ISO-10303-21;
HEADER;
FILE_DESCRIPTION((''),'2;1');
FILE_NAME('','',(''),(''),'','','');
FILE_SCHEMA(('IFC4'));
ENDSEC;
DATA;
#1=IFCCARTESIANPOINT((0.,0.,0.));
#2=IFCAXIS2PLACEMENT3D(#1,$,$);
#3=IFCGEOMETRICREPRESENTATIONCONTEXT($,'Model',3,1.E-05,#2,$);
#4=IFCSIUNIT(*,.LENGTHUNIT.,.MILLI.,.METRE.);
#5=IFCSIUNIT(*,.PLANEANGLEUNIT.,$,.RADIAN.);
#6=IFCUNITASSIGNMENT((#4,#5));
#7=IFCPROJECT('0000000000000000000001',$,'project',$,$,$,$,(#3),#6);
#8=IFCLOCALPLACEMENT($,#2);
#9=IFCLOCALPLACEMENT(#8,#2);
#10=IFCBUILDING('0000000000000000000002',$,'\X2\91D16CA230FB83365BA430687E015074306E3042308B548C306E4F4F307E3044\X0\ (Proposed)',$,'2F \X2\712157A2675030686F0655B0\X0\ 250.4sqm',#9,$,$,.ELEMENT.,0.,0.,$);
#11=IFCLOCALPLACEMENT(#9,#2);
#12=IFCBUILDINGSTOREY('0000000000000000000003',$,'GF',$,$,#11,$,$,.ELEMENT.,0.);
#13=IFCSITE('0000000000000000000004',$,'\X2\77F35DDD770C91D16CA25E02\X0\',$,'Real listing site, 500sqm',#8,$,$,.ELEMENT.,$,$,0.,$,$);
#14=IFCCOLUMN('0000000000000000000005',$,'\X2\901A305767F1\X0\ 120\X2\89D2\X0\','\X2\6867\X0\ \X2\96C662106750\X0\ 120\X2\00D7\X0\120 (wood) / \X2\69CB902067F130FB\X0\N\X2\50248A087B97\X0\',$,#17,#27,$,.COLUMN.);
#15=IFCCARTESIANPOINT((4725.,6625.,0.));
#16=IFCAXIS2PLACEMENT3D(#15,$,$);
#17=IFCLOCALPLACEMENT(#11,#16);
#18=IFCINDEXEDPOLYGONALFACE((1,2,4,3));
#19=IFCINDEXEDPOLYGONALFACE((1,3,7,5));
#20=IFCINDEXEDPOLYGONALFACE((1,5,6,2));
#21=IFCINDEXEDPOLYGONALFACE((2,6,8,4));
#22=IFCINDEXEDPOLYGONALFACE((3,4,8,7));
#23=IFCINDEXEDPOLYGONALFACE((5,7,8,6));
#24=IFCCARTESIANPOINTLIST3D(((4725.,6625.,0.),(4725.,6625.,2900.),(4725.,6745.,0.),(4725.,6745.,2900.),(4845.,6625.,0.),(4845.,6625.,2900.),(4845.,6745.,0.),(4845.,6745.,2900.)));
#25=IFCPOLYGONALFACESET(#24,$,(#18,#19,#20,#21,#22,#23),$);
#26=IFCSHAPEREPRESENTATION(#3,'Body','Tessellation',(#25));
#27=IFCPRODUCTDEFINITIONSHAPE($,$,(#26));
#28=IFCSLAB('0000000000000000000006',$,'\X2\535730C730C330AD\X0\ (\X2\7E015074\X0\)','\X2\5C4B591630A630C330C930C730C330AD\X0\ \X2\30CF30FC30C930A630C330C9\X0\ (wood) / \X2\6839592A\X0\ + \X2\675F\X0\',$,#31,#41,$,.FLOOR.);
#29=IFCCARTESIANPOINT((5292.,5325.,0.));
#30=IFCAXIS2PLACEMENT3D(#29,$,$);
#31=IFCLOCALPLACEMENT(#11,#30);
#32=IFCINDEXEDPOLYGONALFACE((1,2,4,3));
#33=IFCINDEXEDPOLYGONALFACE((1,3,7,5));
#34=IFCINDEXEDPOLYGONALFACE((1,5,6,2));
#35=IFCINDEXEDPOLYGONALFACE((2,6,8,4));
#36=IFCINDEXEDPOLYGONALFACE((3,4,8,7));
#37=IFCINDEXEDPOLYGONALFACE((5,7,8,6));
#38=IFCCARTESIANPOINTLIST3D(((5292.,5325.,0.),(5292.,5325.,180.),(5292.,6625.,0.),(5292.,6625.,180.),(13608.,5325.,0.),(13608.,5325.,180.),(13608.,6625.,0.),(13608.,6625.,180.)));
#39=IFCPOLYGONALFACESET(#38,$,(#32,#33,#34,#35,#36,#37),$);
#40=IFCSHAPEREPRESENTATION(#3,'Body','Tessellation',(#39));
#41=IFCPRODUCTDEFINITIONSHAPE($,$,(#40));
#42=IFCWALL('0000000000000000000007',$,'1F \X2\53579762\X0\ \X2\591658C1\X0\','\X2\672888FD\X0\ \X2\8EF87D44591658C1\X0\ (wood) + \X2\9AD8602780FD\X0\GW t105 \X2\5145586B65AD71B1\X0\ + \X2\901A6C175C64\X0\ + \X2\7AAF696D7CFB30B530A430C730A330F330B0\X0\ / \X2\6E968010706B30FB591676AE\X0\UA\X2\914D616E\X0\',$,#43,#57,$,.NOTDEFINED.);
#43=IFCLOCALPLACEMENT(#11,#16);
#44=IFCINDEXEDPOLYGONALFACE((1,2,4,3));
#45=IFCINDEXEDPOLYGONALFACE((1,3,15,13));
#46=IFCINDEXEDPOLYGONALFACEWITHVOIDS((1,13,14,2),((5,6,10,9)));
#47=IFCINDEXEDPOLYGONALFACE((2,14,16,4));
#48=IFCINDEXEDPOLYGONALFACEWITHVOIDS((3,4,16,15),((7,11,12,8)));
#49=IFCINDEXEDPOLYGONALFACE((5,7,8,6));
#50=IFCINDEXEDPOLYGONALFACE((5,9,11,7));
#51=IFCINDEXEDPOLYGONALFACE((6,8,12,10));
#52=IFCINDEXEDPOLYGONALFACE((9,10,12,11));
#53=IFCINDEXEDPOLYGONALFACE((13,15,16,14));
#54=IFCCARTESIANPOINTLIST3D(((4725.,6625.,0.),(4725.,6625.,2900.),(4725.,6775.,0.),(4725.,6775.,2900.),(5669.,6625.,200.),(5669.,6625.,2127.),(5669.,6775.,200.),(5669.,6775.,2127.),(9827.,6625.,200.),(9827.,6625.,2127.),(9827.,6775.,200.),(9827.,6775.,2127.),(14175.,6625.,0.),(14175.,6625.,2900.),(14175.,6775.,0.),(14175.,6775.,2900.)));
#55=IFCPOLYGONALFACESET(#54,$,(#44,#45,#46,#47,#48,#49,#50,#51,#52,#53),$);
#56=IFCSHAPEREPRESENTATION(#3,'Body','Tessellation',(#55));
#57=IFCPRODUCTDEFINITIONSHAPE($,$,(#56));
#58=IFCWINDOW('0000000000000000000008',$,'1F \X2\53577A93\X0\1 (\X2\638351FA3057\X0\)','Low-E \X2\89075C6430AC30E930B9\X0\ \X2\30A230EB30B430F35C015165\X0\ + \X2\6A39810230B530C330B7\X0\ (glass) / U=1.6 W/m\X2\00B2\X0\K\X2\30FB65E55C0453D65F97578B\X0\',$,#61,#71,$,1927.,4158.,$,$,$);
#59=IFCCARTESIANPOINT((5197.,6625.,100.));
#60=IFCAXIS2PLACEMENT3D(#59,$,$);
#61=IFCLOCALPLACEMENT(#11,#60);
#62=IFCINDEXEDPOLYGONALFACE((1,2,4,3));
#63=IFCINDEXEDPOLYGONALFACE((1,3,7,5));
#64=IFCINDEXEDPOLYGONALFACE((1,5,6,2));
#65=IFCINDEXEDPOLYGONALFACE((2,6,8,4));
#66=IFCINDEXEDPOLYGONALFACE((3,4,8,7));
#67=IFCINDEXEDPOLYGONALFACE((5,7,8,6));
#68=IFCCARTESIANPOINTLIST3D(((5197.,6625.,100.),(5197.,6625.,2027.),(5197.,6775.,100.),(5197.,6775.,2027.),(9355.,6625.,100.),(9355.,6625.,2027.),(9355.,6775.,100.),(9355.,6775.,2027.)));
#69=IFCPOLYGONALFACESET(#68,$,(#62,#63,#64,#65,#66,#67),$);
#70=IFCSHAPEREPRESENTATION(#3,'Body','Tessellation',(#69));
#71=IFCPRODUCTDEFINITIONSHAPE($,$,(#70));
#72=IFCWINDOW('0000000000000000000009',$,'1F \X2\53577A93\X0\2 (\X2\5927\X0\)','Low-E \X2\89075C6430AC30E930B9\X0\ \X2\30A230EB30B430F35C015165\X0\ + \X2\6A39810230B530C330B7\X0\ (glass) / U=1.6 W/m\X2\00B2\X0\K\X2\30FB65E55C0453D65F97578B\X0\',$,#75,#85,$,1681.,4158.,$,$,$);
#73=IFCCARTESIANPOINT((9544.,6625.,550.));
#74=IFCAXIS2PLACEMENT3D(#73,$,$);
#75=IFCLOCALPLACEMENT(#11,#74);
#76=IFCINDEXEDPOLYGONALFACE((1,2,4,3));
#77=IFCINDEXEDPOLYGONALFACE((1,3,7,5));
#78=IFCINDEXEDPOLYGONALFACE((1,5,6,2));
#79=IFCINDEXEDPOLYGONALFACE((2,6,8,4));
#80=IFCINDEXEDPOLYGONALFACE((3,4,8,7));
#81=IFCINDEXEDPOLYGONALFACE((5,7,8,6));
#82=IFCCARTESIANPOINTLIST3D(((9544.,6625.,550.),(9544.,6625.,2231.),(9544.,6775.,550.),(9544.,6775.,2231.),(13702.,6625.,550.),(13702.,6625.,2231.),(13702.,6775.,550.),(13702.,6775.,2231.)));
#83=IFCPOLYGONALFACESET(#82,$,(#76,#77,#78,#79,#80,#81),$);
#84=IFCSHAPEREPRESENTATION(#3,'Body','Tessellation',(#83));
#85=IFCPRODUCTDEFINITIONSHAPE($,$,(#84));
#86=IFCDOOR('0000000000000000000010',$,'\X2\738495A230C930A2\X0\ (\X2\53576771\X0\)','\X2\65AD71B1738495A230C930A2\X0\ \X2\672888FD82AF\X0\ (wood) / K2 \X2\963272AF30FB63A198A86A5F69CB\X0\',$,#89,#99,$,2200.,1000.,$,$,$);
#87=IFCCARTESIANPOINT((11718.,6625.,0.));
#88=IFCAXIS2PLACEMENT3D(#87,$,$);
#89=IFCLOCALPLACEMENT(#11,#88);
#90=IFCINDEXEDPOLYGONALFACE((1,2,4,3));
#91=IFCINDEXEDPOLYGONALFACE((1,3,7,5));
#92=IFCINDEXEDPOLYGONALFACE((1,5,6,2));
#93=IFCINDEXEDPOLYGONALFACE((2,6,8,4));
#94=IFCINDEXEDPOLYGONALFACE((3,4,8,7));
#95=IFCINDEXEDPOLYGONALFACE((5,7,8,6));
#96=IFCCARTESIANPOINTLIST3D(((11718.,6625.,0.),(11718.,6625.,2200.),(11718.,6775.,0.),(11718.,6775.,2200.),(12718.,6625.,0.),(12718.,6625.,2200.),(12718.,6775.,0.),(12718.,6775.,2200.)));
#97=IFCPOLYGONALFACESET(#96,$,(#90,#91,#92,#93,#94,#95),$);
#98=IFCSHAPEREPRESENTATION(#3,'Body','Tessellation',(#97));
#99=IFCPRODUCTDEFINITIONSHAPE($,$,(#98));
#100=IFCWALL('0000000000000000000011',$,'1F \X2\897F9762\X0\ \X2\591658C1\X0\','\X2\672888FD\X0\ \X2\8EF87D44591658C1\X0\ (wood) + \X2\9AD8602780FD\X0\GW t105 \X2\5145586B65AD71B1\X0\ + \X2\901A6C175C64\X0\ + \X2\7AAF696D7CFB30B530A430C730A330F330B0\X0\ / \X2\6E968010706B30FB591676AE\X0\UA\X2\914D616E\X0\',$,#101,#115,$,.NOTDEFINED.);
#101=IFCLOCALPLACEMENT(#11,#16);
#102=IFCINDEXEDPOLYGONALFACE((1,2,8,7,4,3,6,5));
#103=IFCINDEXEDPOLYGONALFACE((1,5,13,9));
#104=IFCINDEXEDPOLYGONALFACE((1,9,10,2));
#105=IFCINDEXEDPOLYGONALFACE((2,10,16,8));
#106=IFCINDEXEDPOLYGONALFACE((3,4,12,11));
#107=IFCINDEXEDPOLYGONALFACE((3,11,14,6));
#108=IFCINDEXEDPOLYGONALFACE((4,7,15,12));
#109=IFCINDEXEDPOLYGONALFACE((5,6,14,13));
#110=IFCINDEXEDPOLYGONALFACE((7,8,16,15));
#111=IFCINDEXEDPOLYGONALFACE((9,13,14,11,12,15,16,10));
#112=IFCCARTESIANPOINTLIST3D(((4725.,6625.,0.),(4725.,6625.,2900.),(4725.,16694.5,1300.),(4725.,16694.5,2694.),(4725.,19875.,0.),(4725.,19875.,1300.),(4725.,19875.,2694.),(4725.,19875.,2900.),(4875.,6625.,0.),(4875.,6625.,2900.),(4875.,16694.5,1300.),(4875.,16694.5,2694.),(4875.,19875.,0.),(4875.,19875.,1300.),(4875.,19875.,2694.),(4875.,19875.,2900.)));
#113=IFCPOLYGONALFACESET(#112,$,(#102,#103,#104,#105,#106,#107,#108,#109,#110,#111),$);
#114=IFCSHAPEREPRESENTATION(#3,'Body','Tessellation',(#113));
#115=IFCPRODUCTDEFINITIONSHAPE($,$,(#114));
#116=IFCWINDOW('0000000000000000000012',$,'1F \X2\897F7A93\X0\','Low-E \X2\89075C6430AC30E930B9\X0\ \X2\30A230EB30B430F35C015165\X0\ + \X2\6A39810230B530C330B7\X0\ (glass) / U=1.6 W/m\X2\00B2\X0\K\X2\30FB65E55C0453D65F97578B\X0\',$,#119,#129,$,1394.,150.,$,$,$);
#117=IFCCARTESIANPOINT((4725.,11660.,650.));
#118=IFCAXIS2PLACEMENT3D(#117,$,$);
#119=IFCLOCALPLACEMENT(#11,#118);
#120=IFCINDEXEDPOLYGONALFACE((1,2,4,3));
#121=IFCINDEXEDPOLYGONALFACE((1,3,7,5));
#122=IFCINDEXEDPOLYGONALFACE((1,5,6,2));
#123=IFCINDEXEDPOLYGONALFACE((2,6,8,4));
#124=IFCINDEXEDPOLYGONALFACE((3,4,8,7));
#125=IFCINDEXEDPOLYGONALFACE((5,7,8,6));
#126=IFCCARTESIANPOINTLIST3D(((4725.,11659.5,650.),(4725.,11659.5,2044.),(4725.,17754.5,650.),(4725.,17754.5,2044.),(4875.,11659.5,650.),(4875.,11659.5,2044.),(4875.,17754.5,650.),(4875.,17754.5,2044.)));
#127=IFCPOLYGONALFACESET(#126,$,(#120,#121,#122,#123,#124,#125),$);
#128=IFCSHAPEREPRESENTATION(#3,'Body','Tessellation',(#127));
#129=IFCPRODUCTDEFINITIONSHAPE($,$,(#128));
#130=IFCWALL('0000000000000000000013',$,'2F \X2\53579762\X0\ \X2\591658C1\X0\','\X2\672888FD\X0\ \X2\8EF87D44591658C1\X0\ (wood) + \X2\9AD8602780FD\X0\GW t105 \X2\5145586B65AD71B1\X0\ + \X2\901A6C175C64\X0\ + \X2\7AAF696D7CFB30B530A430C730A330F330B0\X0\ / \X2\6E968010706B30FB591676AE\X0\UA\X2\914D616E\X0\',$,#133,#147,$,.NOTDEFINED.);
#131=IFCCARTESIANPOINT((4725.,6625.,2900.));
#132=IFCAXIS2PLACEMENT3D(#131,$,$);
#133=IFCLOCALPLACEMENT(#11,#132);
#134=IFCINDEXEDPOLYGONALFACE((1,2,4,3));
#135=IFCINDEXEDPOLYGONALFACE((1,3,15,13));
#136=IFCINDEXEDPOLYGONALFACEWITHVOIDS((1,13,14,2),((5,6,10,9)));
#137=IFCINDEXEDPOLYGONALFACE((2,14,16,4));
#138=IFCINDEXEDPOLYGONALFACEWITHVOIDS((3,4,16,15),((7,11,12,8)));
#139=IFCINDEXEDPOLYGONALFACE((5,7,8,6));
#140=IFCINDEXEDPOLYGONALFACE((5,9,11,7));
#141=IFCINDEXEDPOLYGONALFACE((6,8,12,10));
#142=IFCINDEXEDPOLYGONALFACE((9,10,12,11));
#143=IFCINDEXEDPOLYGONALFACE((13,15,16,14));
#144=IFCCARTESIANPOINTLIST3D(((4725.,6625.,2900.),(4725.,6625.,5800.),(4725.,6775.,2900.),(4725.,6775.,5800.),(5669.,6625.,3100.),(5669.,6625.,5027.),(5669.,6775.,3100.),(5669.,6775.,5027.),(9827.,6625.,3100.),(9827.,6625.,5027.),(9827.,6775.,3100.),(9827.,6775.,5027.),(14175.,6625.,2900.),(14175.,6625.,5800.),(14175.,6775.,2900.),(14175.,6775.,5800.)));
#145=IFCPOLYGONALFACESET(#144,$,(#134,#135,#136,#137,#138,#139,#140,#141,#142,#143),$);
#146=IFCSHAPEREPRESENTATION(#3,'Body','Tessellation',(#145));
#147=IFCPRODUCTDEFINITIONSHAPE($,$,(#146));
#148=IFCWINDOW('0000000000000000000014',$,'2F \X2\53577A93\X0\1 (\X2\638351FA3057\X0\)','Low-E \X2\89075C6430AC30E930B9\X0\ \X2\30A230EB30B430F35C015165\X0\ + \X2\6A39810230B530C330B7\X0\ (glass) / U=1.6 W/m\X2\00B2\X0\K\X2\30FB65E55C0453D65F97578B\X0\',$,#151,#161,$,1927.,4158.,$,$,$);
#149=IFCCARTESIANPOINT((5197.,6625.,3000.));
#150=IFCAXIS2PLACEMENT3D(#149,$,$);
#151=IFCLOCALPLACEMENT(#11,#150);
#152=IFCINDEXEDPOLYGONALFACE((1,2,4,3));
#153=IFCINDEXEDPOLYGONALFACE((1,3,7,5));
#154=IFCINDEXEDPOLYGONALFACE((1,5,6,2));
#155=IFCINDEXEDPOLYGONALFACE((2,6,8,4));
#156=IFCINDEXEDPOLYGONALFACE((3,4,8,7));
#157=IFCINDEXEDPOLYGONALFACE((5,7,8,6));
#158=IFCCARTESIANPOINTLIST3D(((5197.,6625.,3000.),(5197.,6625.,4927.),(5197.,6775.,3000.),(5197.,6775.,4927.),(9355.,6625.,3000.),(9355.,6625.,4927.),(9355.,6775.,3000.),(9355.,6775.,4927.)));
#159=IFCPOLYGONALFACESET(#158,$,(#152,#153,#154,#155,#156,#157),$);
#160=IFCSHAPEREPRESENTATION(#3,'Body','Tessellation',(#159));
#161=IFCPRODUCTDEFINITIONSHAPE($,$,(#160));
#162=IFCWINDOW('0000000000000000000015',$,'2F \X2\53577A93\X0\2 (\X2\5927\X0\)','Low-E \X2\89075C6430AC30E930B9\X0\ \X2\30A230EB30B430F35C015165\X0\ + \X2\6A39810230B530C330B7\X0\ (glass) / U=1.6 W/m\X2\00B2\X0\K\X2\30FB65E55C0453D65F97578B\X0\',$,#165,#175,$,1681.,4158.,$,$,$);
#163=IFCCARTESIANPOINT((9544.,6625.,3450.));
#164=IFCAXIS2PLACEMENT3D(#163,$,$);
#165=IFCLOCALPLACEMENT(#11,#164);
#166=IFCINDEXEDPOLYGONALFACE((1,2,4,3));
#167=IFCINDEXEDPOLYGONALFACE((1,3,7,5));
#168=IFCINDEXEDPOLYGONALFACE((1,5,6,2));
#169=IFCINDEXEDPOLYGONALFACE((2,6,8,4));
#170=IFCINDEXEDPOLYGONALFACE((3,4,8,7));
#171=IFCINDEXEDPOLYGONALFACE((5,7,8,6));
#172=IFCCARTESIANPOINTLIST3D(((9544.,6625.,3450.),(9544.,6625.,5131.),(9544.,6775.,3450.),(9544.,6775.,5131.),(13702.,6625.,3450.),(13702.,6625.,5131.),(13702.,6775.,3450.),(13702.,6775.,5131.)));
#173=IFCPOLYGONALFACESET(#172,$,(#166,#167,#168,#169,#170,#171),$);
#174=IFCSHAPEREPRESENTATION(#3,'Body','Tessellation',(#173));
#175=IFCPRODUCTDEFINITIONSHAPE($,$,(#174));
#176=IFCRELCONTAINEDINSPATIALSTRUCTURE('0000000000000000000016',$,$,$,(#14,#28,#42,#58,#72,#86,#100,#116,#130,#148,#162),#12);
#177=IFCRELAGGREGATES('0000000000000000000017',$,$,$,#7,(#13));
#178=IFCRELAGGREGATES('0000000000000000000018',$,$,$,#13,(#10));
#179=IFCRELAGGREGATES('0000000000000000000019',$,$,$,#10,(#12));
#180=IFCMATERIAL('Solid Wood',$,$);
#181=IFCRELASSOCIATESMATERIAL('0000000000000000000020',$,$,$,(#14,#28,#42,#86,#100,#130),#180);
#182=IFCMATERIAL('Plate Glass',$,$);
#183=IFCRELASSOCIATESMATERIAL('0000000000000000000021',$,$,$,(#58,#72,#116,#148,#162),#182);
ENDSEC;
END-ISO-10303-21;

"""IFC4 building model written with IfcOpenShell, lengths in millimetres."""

from ifc_helpers import new_model, si_unit, frame, frame_2d, origin, place, context, project, spatial, rectangle, extrude, material, element, fill, save


model = new_model("IFC4")

# Units and contexts
model_context = context("Model", 3, precision=1e-05, world=origin())
ifc_project = project(units=[si_unit("LENGTHUNIT", "METRE", prefix="MILLI"), si_unit("PLANEANGLEUNIT", "RADIAN")], contexts=[model_context])

# Site, building, storey
site_placement = place(None, origin())
site = spatial("IfcSite", under=ifc_project, at=site_placement, Name="石川県金沢市", ObjectType="Real listing site, 500sqm", CompositionType="ELEMENT", RefElevation=0.0)
building_placement = place(site_placement, origin())
building = spatial("IfcBuilding", under=site, at=building_placement, Name="金沢・茶室と縁側のある和の住まい (Proposed)", ObjectType="2F 無垢材と漆喰 250.4sqm", CompositionType="ELEMENT", ElevationOfRefHeight=0.0, ElevationOfTerrain=0.0)
storey_placement = place(building_placement, origin())
storey = spatial("IfcBuildingStorey", under=building, at=storey_placement, Name="GF", CompositionType="ELEMENT", Elevation=0.0)

# Column
ifc_material_1 = material(Name="Solid Wood")
column_placement = place(storey_placement, frame((4725.0, 6625.0, 0.0)))
element("IfcColumn", 1, at=column_placement, inside=storey, material=ifc_material_1, Name="通し柱 120角", Description="桧 集成材 120×120 (wood) / 構造柱・N値計算", PredefinedType="COLUMN", context=model_context, shape_type="SweptSolid", body=[
    extrude(rectangle(XDim=120.0, YDim=120.0, at=frame_2d((60.0, 60.0))), frame((4725.0, 6625.0, 0.0)), (0.0, 0.0, 1.0), 2900.0),
])

# Slab
slab_1_placement = place(storey_placement, frame((5292.0, 5325.0, 0.0)))
element("IfcSlab", 2, at=slab_1_placement, inside=storey, material=ifc_material_1, Name="南デッキ (縁側)", Description="屋外ウッドデッキ ハードウッド (wood) / 根太 + 束", PredefinedType="FLOOR", context=model_context, shape_type="SweptSolid", body=[
    extrude(rectangle(XDim=8316.0, YDim=1300.0, at=frame_2d((4158.0, 650.0))), frame((5292.0, 5325.0, 0.0)), (0.0, 0.0, 1.0), 180.0),
])

# Wall, openings, windows, door
wall_1_placement = place(storey_placement, frame((4725.0, 6625.0, 0.0)))
wall_1 = element("IfcWall", 3, at=wall_1_placement, inside=storey, material=ifc_material_1, Name="1F 南面 外壁", Description="木製 軸組外壁 (wood) + 高性能GW t105 充填断熱 + 通気層 + 窯業系サイディング / 準耐火・外皮UA配慮", PredefinedType="NOTDEFINED", context=model_context, shape_type="SweptSolid", body=[
    extrude(rectangle(XDim=9450.0, YDim=150.0, at=frame_2d((4725.0, 75.0))), frame((4725.0, 6625.0, 0.0)), (0.0, 0.0, 1.0), 2900.0),
])
opening_1_placement = place(storey_placement, frame((5197.0, 6625.0, 100.0)))
opening_1 = element("IfcOpeningElement", 4, at=opening_1_placement, cuts=wall_1, PredefinedType="NOTDEFINED", context=model_context, shape_type="SweptSolid", body=[
    extrude(rectangle(XDim=4158.0, YDim=150.0, at=frame_2d((2079.0, 75.0))), frame((5197.0, 6625.0, 100.0)), (0.0, 0.0, 1.0), 1927.0),
])
opening_2_placement = place(storey_placement, frame((9544.0, 6625.0, 550.0)))
opening_2 = element("IfcOpeningElement", 5, at=opening_2_placement, cuts=wall_1, PredefinedType="NOTDEFINED", context=model_context, shape_type="SweptSolid", body=[
    extrude(rectangle(XDim=4158.0, YDim=150.0, at=frame_2d((2079.0, 75.0))), frame((9544.0, 6625.0, 550.0)), (0.0, 0.0, 1.0), 1681.0),
])
opening_3_placement = place(storey_placement, frame((11718.0, 6625.0, 0.0)))
opening_3 = element("IfcOpeningElement", 6, at=opening_3_placement, cuts=wall_1, PredefinedType="NOTDEFINED", context=model_context, shape_type="SweptSolid", body=[
    extrude(rectangle(XDim=1000.0, YDim=150.0, at=frame_2d((500.0, 75.0))), frame((11718.0, 6625.0, 0.0)), (0.0, 0.0, 1.0), 2200.0),
])
ifc_material_2 = material(Name="Plate Glass")
window_1_placement = place(storey_placement, frame((5197.0, 6625.0, 100.0)))
window_1 = element("IfcWindow", 7, at=window_1_placement, inside=storey, material=ifc_material_2, Name="1F 南窓1 (掃出し)", Description="Low-E 複層ガラス アルゴン封入 + 樹脂サッシ (glass) / U=1.6 W/m²K・日射取得型", OverallHeight=1927.0, OverallWidth=4158.0, context=model_context, shape_type="SweptSolid", body=[
    extrude(rectangle(XDim=4158.0, YDim=150.0, at=frame_2d((2079.0, 75.0))), frame((5197.0, 6625.0, 100.0)), (0.0, 0.0, 1.0), 1927.0),
])
fill(opening_1, window_1)
window_2_placement = place(storey_placement, frame((9544.0, 6625.0, 550.0)))
window_2 = element("IfcWindow", 8, at=window_2_placement, inside=storey, material=ifc_material_2, Name="1F 南窓2 (大)", Description="Low-E 複層ガラス アルゴン封入 + 樹脂サッシ (glass) / U=1.6 W/m²K・日射取得型", OverallHeight=1681.0, OverallWidth=4158.0, context=model_context, shape_type="SweptSolid", body=[
    extrude(rectangle(XDim=4158.0, YDim=150.0, at=frame_2d((2079.0, 75.0))), frame((9544.0, 6625.0, 550.0)), (0.0, 0.0, 1.0), 1681.0),
])
fill(opening_2, window_2)
door_placement = place(storey_placement, frame((11718.0, 6625.0, 0.0)))
door = element("IfcDoor", 9, at=door_placement, inside=storey, material=ifc_material_1, Name="玄関ドア (南東)", Description="断熱玄関ドア 木製芯 (wood) / K2 防犯・採風機構", OverallHeight=2200.0, OverallWidth=1000.0, context=model_context, shape_type="SweptSolid", body=[
    extrude(rectangle(XDim=1000.0, YDim=150.0, at=frame_2d((500.0, 75.0))), frame((11718.0, 6625.0, 0.0)), (0.0, 0.0, 1.0), 2200.0),
])
fill(opening_3, door)

# Wall, opening, window
wall_2_placement = place(storey_placement, frame((4725.0, 6625.0, 0.0)))
wall_2 = element("IfcWall", 10, at=wall_2_placement, inside=storey, material=ifc_material_1, Name="1F 西面 外壁", Description="木製 軸組外壁 (wood) + 高性能GW t105 充填断熱 + 通気層 + 窯業系サイディング / 準耐火・外皮UA配慮", PredefinedType="NOTDEFINED", context=model_context, shape_type="SweptSolid", body=[
    extrude(rectangle(XDim=150.0, YDim=13250.0, at=frame_2d((75.0, 6625.0))), frame((4725.0, 6625.0, 0.0)), (0.0, 0.0, 1.0), 2900.0),
])
opening_4_placement = place(storey_placement, frame((4725.0, 11660.0, 650.0)))
opening_4 = element("IfcOpeningElement", 11, at=opening_4_placement, cuts=wall_2, PredefinedType="NOTDEFINED", context=model_context, shape_type="SweptSolid", body=[
    extrude(rectangle(XDim=150.0, YDim=6095.0, at=frame_2d((75.0, 3047.0))), frame((4725.0, 11660.0, 650.0)), (0.0, 0.0, 1.0), 1394.0),
])
window_3_placement = place(storey_placement, frame((4725.0, 11660.0, 650.0)))
window_3 = element("IfcWindow", 12, at=window_3_placement, inside=storey, material=ifc_material_2, Name="1F 西窓", Description="Low-E 複層ガラス アルゴン封入 + 樹脂サッシ (glass) / U=1.6 W/m²K・日射取得型", OverallHeight=1394.0, OverallWidth=150.0, context=model_context, shape_type="SweptSolid", body=[
    extrude(rectangle(XDim=150.0, YDim=6095.0, at=frame_2d((75.0, 3047.0))), frame((4725.0, 11660.0, 650.0)), (0.0, 0.0, 1.0), 1394.0),
])
fill(opening_4, window_3)

# Wall, openings, windows
wall_3_placement = place(storey_placement, frame((4725.0, 6625.0, 2900.0)))
wall_3 = element("IfcWall", 13, at=wall_3_placement, inside=storey, material=ifc_material_1, Name="2F 南面 外壁", Description="木製 軸組外壁 (wood) + 高性能GW t105 充填断熱 + 通気層 + 窯業系サイディング / 準耐火・外皮UA配慮", PredefinedType="NOTDEFINED", context=model_context, shape_type="SweptSolid", body=[
    extrude(rectangle(XDim=9450.0, YDim=150.0, at=frame_2d((4725.0, 75.0))), frame((4725.0, 6625.0, 2900.0)), (0.0, 0.0, 1.0), 2900.0),
])
opening_5_placement = place(storey_placement, frame((5197.0, 6625.0, 3000.0)))
opening_5 = element("IfcOpeningElement", 14, at=opening_5_placement, cuts=wall_3, PredefinedType="NOTDEFINED", context=model_context, shape_type="SweptSolid", body=[
    extrude(rectangle(XDim=4158.0, YDim=150.0, at=frame_2d((2079.0, 75.0))), frame((5197.0, 6625.0, 3000.0)), (0.0, 0.0, 1.0), 1927.0),
])
opening_6_placement = place(storey_placement, frame((9544.0, 6625.0, 3450.0)))
opening_6 = element("IfcOpeningElement", 15, at=opening_6_placement, cuts=wall_3, PredefinedType="NOTDEFINED", context=model_context, shape_type="SweptSolid", body=[
    extrude(rectangle(XDim=4158.0, YDim=150.0, at=frame_2d((2079.0, 75.0))), frame((9544.0, 6625.0, 3450.0)), (0.0, 0.0, 1.0), 1681.0),
])
window_4_placement = place(storey_placement, frame((5197.0, 6625.0, 3000.0)))
window_4 = element("IfcWindow", 16, at=window_4_placement, inside=storey, material=ifc_material_2, Name="2F 南窓1 (掃出し)", Description="Low-E 複層ガラス アルゴン封入 + 樹脂サッシ (glass) / U=1.6 W/m²K・日射取得型", OverallHeight=1927.0, OverallWidth=4158.0, context=model_context, shape_type="SweptSolid", body=[
    extrude(rectangle(XDim=4158.0, YDim=150.0, at=frame_2d((2079.0, 75.0))), frame((5197.0, 6625.0, 3000.0)), (0.0, 0.0, 1.0), 1927.0),
])
fill(opening_5, window_4)
window_5_placement = place(storey_placement, frame((9544.0, 6625.0, 3450.0)))
window_5 = element("IfcWindow", 17, at=window_5_placement, inside=storey, material=ifc_material_2, Name="2F 南窓2 (大)", Description="Low-E 複層ガラス アルゴン封入 + 樹脂サッシ (glass) / U=1.6 W/m²K・日射取得型", OverallHeight=1681.0, OverallWidth=4158.0, context=model_context, shape_type="SweptSolid", body=[
    extrude(rectangle(XDim=4158.0, YDim=150.0, at=frame_2d((2079.0, 75.0))), frame((9544.0, 6625.0, 3450.0)), (0.0, 0.0, 1.0), 1681.0),
])
fill(opening_6, window_5)

save(model, "model.ifc")
